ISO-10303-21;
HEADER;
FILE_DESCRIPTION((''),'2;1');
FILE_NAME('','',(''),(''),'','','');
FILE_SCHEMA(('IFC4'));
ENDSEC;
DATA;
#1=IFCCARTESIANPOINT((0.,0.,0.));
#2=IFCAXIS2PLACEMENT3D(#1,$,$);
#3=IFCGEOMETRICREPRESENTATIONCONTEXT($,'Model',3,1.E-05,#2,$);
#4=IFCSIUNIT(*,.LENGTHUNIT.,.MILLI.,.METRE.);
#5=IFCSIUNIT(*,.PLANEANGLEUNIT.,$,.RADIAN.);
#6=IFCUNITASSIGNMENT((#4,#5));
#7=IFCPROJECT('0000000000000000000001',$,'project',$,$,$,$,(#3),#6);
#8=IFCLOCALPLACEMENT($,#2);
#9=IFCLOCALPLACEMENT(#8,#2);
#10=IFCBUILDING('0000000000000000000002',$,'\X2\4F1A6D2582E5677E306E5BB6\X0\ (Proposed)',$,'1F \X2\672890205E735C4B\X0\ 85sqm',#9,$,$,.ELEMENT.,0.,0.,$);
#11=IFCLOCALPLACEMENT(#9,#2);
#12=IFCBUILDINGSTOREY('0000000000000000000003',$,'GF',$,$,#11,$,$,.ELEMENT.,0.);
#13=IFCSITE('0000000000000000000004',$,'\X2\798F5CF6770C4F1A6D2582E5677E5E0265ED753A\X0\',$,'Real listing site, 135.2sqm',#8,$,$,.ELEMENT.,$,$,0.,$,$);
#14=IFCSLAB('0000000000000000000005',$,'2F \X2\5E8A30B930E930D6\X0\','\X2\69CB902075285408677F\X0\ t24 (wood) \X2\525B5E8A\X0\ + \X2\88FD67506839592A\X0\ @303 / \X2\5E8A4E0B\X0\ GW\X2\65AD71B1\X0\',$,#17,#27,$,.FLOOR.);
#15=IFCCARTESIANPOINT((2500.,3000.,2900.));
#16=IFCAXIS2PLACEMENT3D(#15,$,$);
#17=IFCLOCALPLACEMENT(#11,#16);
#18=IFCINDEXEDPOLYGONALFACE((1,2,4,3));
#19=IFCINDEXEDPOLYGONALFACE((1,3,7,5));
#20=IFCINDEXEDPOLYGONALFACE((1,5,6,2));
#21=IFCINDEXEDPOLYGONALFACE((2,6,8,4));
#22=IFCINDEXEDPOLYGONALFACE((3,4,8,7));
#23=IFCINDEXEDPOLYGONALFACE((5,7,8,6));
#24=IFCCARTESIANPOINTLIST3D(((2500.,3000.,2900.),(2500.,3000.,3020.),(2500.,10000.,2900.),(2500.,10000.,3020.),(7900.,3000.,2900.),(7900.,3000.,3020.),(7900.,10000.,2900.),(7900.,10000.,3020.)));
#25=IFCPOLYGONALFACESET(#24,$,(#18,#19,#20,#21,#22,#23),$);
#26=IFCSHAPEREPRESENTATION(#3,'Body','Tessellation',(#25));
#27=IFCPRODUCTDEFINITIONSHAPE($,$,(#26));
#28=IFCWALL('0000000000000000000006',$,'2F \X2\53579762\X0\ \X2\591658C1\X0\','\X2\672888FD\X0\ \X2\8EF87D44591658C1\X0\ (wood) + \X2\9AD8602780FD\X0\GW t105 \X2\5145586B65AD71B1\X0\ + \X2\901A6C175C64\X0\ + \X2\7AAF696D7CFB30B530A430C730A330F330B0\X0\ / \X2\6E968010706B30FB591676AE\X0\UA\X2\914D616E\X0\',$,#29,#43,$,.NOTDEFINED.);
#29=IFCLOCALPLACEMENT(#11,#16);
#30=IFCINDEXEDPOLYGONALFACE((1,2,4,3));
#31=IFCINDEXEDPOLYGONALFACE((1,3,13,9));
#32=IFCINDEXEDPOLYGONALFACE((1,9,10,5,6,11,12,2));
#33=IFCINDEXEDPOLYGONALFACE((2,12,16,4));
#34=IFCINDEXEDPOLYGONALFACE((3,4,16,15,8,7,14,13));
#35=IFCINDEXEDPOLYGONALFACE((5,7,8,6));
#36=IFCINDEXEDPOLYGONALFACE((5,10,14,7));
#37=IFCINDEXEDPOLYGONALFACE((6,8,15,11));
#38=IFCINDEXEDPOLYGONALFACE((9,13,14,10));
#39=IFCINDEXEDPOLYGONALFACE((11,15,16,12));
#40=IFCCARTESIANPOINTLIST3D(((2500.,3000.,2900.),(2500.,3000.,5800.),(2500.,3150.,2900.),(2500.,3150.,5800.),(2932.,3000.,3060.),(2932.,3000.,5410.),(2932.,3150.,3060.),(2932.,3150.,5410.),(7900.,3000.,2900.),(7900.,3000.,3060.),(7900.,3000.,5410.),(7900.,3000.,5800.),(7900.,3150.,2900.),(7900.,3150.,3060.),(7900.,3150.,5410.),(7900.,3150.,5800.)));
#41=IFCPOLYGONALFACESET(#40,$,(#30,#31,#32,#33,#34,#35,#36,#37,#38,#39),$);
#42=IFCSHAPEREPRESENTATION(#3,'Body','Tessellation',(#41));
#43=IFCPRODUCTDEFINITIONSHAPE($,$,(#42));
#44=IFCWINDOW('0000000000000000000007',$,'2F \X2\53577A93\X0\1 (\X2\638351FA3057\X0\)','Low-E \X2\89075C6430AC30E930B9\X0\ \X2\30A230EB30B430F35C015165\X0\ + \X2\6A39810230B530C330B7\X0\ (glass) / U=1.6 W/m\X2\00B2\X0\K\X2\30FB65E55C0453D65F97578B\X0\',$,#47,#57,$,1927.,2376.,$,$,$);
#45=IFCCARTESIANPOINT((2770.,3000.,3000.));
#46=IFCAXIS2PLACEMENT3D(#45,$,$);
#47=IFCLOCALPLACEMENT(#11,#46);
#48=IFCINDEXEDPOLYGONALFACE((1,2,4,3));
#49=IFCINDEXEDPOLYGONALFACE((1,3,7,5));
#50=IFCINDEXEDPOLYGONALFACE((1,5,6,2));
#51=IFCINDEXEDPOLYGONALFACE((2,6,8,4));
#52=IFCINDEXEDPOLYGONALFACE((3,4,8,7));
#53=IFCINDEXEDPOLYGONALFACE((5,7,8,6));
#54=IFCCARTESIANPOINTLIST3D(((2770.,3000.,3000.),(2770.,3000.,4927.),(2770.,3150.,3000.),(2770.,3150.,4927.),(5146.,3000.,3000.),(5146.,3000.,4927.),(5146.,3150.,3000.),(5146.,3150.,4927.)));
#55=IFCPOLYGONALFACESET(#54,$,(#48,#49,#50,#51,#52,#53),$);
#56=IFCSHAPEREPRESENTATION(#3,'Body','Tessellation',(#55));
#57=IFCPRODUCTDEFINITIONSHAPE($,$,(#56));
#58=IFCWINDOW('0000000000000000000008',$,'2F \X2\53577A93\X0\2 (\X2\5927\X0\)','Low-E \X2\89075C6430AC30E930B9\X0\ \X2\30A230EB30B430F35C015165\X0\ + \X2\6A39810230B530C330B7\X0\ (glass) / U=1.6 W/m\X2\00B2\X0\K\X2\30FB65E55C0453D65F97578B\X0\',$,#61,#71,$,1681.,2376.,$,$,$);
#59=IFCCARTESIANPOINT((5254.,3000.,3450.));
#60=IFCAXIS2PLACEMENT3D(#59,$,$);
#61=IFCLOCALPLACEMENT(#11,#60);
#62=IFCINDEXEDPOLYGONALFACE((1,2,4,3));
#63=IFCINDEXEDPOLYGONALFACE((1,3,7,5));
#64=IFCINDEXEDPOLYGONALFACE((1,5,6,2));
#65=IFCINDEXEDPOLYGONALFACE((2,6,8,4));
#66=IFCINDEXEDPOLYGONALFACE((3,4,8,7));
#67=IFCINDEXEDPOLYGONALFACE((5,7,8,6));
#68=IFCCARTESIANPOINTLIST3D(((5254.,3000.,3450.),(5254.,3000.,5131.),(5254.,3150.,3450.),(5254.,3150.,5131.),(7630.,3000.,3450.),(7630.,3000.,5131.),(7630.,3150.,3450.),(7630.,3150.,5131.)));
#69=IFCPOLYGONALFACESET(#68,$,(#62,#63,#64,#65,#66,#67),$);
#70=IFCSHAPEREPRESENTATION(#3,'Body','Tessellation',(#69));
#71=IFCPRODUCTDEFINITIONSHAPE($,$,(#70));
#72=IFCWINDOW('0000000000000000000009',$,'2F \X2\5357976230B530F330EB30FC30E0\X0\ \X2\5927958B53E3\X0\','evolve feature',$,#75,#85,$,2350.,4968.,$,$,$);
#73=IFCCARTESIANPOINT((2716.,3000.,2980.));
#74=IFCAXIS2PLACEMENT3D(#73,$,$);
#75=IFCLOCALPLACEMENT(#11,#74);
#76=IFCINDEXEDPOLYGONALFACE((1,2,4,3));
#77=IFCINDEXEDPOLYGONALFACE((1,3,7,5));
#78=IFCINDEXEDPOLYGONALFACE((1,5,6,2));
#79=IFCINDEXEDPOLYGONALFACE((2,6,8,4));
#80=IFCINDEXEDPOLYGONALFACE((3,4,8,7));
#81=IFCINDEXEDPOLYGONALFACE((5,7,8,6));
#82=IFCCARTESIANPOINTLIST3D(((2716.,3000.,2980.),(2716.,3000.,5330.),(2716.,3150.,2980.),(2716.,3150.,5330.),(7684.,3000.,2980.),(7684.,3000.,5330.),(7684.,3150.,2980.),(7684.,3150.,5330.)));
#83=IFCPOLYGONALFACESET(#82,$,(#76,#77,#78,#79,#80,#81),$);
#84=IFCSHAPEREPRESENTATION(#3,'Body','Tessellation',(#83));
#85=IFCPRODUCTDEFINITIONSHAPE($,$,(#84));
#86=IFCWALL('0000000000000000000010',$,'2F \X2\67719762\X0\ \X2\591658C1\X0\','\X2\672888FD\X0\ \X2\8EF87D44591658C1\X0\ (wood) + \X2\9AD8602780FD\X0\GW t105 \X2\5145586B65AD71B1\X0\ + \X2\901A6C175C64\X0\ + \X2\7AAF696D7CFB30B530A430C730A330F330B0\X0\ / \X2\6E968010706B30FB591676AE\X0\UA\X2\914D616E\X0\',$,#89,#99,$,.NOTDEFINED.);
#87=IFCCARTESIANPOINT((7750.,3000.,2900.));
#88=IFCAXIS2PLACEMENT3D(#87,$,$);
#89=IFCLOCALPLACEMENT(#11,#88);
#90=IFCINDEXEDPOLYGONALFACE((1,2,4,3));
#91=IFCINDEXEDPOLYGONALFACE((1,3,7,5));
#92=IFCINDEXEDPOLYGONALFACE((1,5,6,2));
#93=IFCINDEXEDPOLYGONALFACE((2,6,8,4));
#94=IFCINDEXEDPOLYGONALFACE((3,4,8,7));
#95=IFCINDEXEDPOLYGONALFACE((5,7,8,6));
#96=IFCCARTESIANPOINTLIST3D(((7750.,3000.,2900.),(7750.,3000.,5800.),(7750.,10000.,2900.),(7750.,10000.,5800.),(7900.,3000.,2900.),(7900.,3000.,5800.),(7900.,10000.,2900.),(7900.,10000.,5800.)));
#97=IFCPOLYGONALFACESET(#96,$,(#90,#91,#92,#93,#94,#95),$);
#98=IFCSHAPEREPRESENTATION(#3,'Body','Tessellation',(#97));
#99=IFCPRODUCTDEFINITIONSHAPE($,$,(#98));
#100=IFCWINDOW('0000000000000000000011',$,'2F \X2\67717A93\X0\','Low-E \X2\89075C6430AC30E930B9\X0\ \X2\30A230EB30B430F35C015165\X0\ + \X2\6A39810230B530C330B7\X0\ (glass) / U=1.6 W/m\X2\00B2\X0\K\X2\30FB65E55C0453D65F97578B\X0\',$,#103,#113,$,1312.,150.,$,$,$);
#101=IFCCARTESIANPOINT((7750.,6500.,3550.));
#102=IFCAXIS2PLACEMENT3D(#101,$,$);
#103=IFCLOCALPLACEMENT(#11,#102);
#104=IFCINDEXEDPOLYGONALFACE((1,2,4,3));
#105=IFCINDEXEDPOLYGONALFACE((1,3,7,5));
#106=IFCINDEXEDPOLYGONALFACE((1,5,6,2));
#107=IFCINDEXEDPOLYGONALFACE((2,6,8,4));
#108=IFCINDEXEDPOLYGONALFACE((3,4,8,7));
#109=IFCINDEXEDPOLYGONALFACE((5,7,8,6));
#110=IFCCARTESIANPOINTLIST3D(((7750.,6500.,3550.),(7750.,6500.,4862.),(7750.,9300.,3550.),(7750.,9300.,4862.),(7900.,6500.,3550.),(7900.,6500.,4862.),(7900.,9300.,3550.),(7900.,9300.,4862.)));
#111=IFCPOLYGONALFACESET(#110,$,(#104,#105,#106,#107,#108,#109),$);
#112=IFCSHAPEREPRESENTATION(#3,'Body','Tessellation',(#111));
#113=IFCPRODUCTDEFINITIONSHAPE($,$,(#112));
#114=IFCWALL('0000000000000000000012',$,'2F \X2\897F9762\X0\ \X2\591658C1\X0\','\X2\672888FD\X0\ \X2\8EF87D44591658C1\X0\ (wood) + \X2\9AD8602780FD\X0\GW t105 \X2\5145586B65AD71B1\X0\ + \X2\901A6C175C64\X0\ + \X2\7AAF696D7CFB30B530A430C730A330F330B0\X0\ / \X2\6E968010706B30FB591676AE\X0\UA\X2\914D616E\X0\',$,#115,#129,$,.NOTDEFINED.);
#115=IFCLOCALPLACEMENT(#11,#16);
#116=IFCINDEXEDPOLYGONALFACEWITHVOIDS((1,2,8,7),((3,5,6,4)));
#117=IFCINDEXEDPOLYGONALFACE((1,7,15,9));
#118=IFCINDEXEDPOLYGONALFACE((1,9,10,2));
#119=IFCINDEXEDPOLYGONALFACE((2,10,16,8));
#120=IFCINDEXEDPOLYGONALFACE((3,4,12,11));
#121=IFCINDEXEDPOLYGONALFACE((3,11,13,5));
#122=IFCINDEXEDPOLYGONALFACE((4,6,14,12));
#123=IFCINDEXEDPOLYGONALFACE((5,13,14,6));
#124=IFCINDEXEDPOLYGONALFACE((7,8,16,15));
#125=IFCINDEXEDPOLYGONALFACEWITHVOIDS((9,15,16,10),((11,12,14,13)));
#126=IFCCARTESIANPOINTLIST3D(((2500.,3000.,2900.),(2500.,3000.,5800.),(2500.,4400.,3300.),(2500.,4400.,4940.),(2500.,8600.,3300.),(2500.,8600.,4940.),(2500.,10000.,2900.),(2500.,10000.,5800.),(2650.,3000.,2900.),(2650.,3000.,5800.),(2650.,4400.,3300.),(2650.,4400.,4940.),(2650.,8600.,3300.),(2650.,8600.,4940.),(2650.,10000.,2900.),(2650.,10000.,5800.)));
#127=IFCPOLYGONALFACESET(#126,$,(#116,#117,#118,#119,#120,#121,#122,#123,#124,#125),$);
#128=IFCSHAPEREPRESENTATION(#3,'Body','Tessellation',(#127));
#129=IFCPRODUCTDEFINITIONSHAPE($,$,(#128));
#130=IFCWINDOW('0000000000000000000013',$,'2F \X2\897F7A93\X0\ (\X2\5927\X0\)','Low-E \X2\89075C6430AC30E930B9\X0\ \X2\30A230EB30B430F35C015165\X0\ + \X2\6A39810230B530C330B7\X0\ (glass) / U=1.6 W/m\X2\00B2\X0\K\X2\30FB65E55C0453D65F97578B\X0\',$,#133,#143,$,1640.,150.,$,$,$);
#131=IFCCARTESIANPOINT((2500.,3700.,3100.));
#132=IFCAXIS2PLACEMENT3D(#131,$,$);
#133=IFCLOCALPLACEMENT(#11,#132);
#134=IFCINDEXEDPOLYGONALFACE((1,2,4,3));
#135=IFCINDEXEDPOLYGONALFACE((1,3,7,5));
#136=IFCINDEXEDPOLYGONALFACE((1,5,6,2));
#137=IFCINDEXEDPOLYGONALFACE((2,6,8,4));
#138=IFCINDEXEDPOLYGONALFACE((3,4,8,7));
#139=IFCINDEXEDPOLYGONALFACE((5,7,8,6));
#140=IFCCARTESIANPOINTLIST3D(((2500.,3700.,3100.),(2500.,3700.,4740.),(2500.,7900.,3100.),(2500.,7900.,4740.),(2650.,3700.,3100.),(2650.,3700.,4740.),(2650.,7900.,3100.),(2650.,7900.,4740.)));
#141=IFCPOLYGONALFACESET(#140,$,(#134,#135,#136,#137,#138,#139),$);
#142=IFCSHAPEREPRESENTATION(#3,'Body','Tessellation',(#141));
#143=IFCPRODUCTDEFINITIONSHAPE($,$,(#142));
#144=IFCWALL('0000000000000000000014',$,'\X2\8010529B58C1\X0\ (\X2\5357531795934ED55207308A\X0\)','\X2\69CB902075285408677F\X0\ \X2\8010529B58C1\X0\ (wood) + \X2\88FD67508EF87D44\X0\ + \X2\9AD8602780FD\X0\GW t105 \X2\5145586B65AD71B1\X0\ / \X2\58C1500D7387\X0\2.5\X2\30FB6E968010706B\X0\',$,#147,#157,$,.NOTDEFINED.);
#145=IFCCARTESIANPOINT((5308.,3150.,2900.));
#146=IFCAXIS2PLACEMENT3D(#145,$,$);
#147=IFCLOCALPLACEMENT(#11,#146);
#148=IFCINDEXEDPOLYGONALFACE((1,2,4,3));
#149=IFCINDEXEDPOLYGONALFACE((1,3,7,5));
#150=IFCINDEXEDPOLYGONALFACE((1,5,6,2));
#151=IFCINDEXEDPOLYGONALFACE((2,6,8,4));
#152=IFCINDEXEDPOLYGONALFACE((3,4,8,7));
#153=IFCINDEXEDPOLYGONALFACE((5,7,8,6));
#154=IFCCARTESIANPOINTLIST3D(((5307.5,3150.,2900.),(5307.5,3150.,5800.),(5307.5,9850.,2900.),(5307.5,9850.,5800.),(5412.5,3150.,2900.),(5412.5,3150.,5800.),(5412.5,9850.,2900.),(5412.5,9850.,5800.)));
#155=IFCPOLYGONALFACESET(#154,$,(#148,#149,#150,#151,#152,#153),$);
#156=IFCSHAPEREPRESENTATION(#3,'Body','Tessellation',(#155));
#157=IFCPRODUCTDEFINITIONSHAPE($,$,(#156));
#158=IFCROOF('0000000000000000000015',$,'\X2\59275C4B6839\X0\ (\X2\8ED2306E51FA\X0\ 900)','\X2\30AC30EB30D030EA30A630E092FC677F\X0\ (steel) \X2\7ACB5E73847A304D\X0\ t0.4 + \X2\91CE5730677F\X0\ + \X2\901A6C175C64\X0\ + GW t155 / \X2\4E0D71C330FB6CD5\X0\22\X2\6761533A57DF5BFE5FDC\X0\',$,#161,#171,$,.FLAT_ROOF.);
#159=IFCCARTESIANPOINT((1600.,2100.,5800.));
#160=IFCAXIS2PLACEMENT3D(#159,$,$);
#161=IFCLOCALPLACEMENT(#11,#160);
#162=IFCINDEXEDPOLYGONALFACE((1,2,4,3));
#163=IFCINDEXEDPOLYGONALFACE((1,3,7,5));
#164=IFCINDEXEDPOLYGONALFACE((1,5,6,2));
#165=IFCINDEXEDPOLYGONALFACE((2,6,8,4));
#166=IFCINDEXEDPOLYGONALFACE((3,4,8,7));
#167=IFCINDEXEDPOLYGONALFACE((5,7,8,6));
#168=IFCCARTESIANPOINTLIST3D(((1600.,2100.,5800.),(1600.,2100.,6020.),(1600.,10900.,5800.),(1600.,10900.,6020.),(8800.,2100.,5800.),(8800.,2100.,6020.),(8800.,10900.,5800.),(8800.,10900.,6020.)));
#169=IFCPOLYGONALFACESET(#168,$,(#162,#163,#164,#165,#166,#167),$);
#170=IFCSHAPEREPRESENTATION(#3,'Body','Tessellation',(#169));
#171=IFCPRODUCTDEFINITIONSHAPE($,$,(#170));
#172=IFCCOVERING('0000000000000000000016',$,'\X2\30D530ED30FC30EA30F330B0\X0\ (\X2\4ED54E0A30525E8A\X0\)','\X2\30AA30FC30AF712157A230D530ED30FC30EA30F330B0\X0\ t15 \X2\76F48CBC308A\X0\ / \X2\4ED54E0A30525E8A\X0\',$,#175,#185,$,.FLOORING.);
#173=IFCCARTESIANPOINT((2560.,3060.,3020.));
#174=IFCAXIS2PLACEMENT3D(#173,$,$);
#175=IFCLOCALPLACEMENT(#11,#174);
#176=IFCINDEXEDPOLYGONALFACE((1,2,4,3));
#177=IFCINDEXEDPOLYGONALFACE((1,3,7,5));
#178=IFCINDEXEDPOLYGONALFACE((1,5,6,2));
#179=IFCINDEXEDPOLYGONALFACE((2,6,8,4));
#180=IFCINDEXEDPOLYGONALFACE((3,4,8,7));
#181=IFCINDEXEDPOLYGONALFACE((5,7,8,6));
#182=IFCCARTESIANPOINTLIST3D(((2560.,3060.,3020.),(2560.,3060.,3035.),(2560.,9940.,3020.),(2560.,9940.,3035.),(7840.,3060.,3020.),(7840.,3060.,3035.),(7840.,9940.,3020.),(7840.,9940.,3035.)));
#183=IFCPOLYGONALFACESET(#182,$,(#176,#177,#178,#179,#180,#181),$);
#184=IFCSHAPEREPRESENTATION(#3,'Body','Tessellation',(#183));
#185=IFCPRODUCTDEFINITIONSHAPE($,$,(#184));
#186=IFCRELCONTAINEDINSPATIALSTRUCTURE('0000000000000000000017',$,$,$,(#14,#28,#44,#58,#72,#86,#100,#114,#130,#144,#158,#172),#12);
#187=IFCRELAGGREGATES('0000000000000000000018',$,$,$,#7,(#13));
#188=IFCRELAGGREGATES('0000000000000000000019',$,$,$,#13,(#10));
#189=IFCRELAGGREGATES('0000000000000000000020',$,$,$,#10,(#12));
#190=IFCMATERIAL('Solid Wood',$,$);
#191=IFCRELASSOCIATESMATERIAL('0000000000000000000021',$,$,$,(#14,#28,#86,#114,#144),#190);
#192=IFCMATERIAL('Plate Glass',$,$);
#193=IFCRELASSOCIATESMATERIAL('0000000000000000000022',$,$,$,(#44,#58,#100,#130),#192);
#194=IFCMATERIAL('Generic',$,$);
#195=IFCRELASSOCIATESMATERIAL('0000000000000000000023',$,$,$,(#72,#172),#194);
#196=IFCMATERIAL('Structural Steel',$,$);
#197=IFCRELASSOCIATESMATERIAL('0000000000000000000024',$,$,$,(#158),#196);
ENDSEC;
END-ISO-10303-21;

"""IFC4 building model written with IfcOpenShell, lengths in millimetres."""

from ifc_helpers import new_model, si_unit, frame, frame_2d, origin, place, context, project, spatial, rectangle, extrude, material, element, fill, save


model = new_model("IFC4")

# Units and contexts
model_context = context("Model", 3, precision=1e-05, world=origin())
ifc_project = project(units=[si_unit("LENGTHUNIT", "METRE", prefix="MILLI"), si_unit("PLANEANGLEUNIT", "RADIAN")], contexts=[model_context])

# Site, building, storey
site_placement = place(None, origin())
site = spatial("IfcSite", under=ifc_project, at=site_placement, Name="福島県会津若松市旭町", ObjectType="Real listing site, 135.2sqm", CompositionType="ELEMENT", RefElevation=0.0)
building_placement = place(site_placement, origin())
building = spatial("IfcBuilding", under=site, at=building_placement, Name="会津若松の家 (Proposed)", ObjectType="1F 木造平屋 85sqm", CompositionType="ELEMENT", ElevationOfRefHeight=0.0, ElevationOfTerrain=0.0)
storey_placement = place(building_placement, origin())
storey = spatial("IfcBuildingStorey", under=building, at=storey_placement, Name="GF", CompositionType="ELEMENT", Elevation=0.0)

# Slab
ifc_material_1 = material(Name="Solid Wood")
slab_placement = place(storey_placement, frame((2500.0, 3000.0, 2900.0)))
element("IfcSlab", 1, at=slab_placement, inside=storey, material=ifc_material_1, Name="2F 床スラブ", Description="構造用合板 t24 (wood) 剛床 + 製材根太 @303 / 床下 GW断熱", PredefinedType="FLOOR", context=model_context, shape_type="SweptSolid", body=[
    extrude(rectangle(XDim=5400.0, YDim=7000.0, at=frame_2d((2700.0, 3500.0))), frame((2500.0, 3000.0, 2900.0)), (0.0, 0.0, 1.0), 120.0),
])

# Wall, openings, windows
wall_1_placement = place(storey_placement, frame((2500.0, 3000.0, 2900.0)))
wall_1 = element("IfcWall", 2, at=wall_1_placement, inside=storey, material=ifc_material_1, Name="2F 南面 外壁", Description="木製 軸組外壁 (wood) + 高性能GW t105 充填断熱 + 通気層 + 窯業系サイディング / 準耐火・外皮UA配慮", PredefinedType="NOTDEFINED", context=model_context, shape_type="SweptSolid", body=[
    extrude(rectangle(XDim=5400.0, YDim=150.0, at=frame_2d((2700.0, 75.0))), frame((2500.0, 3000.0, 2900.0)), (0.0, 0.0, 1.0), 2900.0),
])
opening_1_placement = place(storey_placement, frame((2770.0, 3000.0, 3000.0)))
opening_1 = element("IfcOpeningElement", 3, at=opening_1_placement, cuts=wall_1, PredefinedType="NOTDEFINED", context=model_context, shape_type="SweptSolid", body=[
    extrude(rectangle(XDim=2376.0, YDim=150.0, at=frame_2d((1188.0, 75.0))), frame((2770.0, 3000.0, 3000.0)), (0.0, 0.0, 1.0), 1927.0),
])
opening_2_placement = place(storey_placement, frame((5254.0, 3000.0, 3450.0)))
opening_2 = element("IfcOpeningElement", 4, at=opening_2_placement, cuts=wall_1, PredefinedType="NOTDEFINED", context=model_context, shape_type="SweptSolid", body=[
    extrude(rectangle(XDim=2376.0, YDim=150.0, at=frame_2d((1188.0, 75.0))), frame((5254.0, 3000.0, 3450.0)), (0.0, 0.0, 1.0), 1681.0),
])
opening_3_placement = place(storey_placement, frame((2716.0, 3000.0, 2980.0)))
opening_3 = element("IfcOpeningElement", 5, at=opening_3_placement, cuts=wall_1, PredefinedType="NOTDEFINED", context=model_context, shape_type="SweptSolid", body=[
    extrude(rectangle(XDim=4968.0, YDim=150.0, at=frame_2d((2484.0, 75.0))), frame((2716.0, 3000.0, 2980.0)), (0.0, 0.0, 1.0), 2350.0),
])
ifc_material_2 = material(Name="Plate Glass")
window_1_placement = place(storey_placement, frame((2770.0, 3000.0, 3000.0)))
window_1 = element("IfcWindow", 6, at=window_1_placement, inside=storey, material=ifc_material_2, Name="2F 南窓1 (掃出し)", Description="Low-E 複層ガラス アルゴン封入 + 樹脂サッシ (glass) / U=1.6 W/m²K・日射取得型", OverallHeight=1927.0, OverallWidth=2376.0, context=model_context, shape_type="SweptSolid", body=[
    extrude(rectangle(XDim=2376.0, YDim=150.0, at=frame_2d((1188.0, 75.0))), frame((2770.0, 3000.0, 3000.0)), (0.0, 0.0, 1.0), 1927.0),
])
fill(opening_1, window_1)
window_2_placement = place(storey_placement, frame((5254.0, 3000.0, 3450.0)))
window_2 = element("IfcWindow", 7, at=window_2_placement, inside=storey, material=ifc_material_2, Name="2F 南窓2 (大)", Description="Low-E 複層ガラス アルゴン封入 + 樹脂サッシ (glass) / U=1.6 W/m²K・日射取得型", OverallHeight=1681.0, OverallWidth=2376.0, context=model_context, shape_type="SweptSolid", body=[
    extrude(rectangle(XDim=2376.0, YDim=150.0, at=frame_2d((1188.0, 75.0))), frame((5254.0, 3000.0, 3450.0)), (0.0, 0.0, 1.0), 1681.0),
])
fill(opening_2, window_2)
ifc_material_3 = material(Name="Generic")
window_3_placement = place(storey_placement, frame((2716.0, 3000.0, 2980.0)))
window_3 = element("IfcWindow", 8, at=window_3_placement, inside=storey, material=ifc_material_3, Name="2F 南面サンルーム 大開口", Description="evolve feature", OverallHeight=2350.0, OverallWidth=4968.0, context=model_context, shape_type="SweptSolid", body=[
    extrude(rectangle(XDim=4968.0, YDim=150.0, at=frame_2d((2484.0, 75.0))), frame((2716.0, 3000.0, 2980.0)), (0.0, 0.0, 1.0), 2350.0),
])
fill(opening_3, window_3)

# Walls, openings, windows
wall_2_placement = place(storey_placement, frame((7750.0, 3000.0, 2900.0)))
wall_2 = element("IfcWall", 9, at=wall_2_placement, inside=storey, material=ifc_material_1, Name="2F 東面 外壁", Description="木製 軸組外壁 (wood) + 高性能GW t105 充填断熱 + 通気層 + 窯業系サイディング / 準耐火・外皮UA配慮", PredefinedType="NOTDEFINED", context=model_context, shape_type="SweptSolid", body=[
    extrude(rectangle(XDim=150.0, YDim=7000.0, at=frame_2d((75.0, 3500.0))), frame((7750.0, 3000.0, 2900.0)), (0.0, 0.0, 1.0), 2900.0),
])
opening_4_placement = place(storey_placement, frame((7750.0, 6500.0, 3550.0)))
opening_4 = element("IfcOpeningElement", 10, at=opening_4_placement, cuts=wall_2, PredefinedType="NOTDEFINED", context=model_context, shape_type="SweptSolid", body=[
    extrude(rectangle(XDim=150.0, YDim=2800.0, at=frame_2d((75.0, 1400.0))), frame((7750.0, 6500.0, 3550.0)), (0.0, 0.0, 1.0), 1312.0),
])
window_4_placement = place(storey_placement, frame((7750.0, 6500.0, 3550.0)))
window_4 = element("IfcWindow", 11, at=window_4_placement, inside=storey, material=ifc_material_2, Name="2F 東窓", Description="Low-E 複層ガラス アルゴン封入 + 樹脂サッシ (glass) / U=1.6 W/m²K・日射取得型", OverallHeight=1312.0, OverallWidth=150.0, context=model_context, shape_type="SweptSolid", body=[
    extrude(rectangle(XDim=150.0, YDim=2800.0, at=frame_2d((75.0, 1400.0))), frame((7750.0, 6500.0, 3550.0)), (0.0, 0.0, 1.0), 1312.0),
])
fill(opening_4, window_4)
wall_3_placement = place(storey_placement, frame((2500.0, 3000.0, 2900.0)))
wall_3 = element("IfcWall", 12, at=wall_3_placement, inside=storey, material=ifc_material_1, Name="2F 西面 外壁", Description="木製 軸組外壁 (wood) + 高性能GW t105 充填断熱 + 通気層 + 窯業系サイディング / 準耐火・外皮UA配慮", PredefinedType="NOTDEFINED", context=model_context, shape_type="SweptSolid", body=[
    extrude(rectangle(XDim=150.0, YDim=7000.0, at=frame_2d((75.0, 3500.0))), frame((2500.0, 3000.0, 2900.0)), (0.0, 0.0, 1.0), 2900.0),
])
opening_5_placement = place(storey_placement, frame((2500.0, 3700.0, 3100.0)))
opening_5 = element("IfcOpeningElement", 13, at=opening_5_placement, cuts=wall_3, PredefinedType="NOTDEFINED", context=model_context, shape_type="SweptSolid", body=[
    extrude(rectangle(XDim=150.0, YDim=4200.0, at=frame_2d((75.0, 2100.0))), frame((2500.0, 3700.0, 3100.0)), (0.0, 0.0, 1.0), 1640.0),
])
window_5_placement = place(storey_placement, frame((2500.0, 3700.0, 3100.0)))
window_5 = element("IfcWindow", 14, at=window_5_placement, inside=storey, material=ifc_material_2, Name="2F 西窓 (大)", Description="Low-E 複層ガラス アルゴン封入 + 樹脂サッシ (glass) / U=1.6 W/m²K・日射取得型", OverallHeight=1640.0, OverallWidth=150.0, context=model_context, shape_type="SweptSolid", body=[
    extrude(rectangle(XDim=150.0, YDim=4200.0, at=frame_2d((75.0, 2100.0))), frame((2500.0, 3700.0, 3100.0)), (0.0, 0.0, 1.0), 1640.0),
])
fill(opening_5, window_5)

# Wall
wall_4_placement = place(storey_placement, frame((5308.0, 3150.0, 2900.0)))
element("IfcWall", 15, at=wall_4_placement, inside=storey, material=ifc_material_1, Name="耐力壁 (南北間仕切り)", Description="構造用合板 耐力壁 (wood) + 製材軸組 + 高性能GW t105 充填断熱 / 壁倍率2.5・準耐火", PredefinedType="NOTDEFINED", context=model_context, shape_type="SweptSolid", body=[
    extrude(rectangle(XDim=105.0, YDim=6700.0, at=frame_2d((52.0, 3350.0))), frame((5308.0, 3150.0, 2900.0)), (0.0, 0.0, 1.0), 2900.0),
])

# Roof
ifc_material_4 = material(Name="Structural Steel")
roof_placement = place(storey_placement, frame((1600.0, 2100.0, 5800.0)))
element("IfcRoof", 16, at=roof_placement, inside=storey, material=ifc_material_4, Name="大屋根 (軒の出 900)", Description="ガルバリウム鋼板 (steel) 立平葺き t0.4 + 野地板 + 通気層 + GW t155 / 不燃・法22条区域対応", PredefinedType="FLAT_ROOF", context=model_context, shape_type="SweptSolid", body=[
    extrude(rectangle(XDim=7200.0, YDim=8800.0, at=frame_2d((3600.0, 4400.0))), frame((1600.0, 2100.0, 5800.0)), (0.0, 0.0, 1.0), 220.0),
])

# Covering
covering_placement = place(storey_placement, frame((2560.0, 3060.0, 3020.0)))
element("IfcCovering", 17, at=covering_placement, inside=storey, material=ifc_material_3, Name="フローリング (仕上げ床)", Description="オーク無垢フローリング t15 直貼り / 仕上げ床", PredefinedType="FLOORING", context=model_context, shape_type="SweptSolid", body=[
    extrude(rectangle(XDim=5280.0, YDim=6880.0, at=frame_2d((2640.0, 3440.0))), frame((2560.0, 3060.0, 3020.0)), (0.0, 0.0, 1.0), 15.0),
])

save(model, "model.ifc")
